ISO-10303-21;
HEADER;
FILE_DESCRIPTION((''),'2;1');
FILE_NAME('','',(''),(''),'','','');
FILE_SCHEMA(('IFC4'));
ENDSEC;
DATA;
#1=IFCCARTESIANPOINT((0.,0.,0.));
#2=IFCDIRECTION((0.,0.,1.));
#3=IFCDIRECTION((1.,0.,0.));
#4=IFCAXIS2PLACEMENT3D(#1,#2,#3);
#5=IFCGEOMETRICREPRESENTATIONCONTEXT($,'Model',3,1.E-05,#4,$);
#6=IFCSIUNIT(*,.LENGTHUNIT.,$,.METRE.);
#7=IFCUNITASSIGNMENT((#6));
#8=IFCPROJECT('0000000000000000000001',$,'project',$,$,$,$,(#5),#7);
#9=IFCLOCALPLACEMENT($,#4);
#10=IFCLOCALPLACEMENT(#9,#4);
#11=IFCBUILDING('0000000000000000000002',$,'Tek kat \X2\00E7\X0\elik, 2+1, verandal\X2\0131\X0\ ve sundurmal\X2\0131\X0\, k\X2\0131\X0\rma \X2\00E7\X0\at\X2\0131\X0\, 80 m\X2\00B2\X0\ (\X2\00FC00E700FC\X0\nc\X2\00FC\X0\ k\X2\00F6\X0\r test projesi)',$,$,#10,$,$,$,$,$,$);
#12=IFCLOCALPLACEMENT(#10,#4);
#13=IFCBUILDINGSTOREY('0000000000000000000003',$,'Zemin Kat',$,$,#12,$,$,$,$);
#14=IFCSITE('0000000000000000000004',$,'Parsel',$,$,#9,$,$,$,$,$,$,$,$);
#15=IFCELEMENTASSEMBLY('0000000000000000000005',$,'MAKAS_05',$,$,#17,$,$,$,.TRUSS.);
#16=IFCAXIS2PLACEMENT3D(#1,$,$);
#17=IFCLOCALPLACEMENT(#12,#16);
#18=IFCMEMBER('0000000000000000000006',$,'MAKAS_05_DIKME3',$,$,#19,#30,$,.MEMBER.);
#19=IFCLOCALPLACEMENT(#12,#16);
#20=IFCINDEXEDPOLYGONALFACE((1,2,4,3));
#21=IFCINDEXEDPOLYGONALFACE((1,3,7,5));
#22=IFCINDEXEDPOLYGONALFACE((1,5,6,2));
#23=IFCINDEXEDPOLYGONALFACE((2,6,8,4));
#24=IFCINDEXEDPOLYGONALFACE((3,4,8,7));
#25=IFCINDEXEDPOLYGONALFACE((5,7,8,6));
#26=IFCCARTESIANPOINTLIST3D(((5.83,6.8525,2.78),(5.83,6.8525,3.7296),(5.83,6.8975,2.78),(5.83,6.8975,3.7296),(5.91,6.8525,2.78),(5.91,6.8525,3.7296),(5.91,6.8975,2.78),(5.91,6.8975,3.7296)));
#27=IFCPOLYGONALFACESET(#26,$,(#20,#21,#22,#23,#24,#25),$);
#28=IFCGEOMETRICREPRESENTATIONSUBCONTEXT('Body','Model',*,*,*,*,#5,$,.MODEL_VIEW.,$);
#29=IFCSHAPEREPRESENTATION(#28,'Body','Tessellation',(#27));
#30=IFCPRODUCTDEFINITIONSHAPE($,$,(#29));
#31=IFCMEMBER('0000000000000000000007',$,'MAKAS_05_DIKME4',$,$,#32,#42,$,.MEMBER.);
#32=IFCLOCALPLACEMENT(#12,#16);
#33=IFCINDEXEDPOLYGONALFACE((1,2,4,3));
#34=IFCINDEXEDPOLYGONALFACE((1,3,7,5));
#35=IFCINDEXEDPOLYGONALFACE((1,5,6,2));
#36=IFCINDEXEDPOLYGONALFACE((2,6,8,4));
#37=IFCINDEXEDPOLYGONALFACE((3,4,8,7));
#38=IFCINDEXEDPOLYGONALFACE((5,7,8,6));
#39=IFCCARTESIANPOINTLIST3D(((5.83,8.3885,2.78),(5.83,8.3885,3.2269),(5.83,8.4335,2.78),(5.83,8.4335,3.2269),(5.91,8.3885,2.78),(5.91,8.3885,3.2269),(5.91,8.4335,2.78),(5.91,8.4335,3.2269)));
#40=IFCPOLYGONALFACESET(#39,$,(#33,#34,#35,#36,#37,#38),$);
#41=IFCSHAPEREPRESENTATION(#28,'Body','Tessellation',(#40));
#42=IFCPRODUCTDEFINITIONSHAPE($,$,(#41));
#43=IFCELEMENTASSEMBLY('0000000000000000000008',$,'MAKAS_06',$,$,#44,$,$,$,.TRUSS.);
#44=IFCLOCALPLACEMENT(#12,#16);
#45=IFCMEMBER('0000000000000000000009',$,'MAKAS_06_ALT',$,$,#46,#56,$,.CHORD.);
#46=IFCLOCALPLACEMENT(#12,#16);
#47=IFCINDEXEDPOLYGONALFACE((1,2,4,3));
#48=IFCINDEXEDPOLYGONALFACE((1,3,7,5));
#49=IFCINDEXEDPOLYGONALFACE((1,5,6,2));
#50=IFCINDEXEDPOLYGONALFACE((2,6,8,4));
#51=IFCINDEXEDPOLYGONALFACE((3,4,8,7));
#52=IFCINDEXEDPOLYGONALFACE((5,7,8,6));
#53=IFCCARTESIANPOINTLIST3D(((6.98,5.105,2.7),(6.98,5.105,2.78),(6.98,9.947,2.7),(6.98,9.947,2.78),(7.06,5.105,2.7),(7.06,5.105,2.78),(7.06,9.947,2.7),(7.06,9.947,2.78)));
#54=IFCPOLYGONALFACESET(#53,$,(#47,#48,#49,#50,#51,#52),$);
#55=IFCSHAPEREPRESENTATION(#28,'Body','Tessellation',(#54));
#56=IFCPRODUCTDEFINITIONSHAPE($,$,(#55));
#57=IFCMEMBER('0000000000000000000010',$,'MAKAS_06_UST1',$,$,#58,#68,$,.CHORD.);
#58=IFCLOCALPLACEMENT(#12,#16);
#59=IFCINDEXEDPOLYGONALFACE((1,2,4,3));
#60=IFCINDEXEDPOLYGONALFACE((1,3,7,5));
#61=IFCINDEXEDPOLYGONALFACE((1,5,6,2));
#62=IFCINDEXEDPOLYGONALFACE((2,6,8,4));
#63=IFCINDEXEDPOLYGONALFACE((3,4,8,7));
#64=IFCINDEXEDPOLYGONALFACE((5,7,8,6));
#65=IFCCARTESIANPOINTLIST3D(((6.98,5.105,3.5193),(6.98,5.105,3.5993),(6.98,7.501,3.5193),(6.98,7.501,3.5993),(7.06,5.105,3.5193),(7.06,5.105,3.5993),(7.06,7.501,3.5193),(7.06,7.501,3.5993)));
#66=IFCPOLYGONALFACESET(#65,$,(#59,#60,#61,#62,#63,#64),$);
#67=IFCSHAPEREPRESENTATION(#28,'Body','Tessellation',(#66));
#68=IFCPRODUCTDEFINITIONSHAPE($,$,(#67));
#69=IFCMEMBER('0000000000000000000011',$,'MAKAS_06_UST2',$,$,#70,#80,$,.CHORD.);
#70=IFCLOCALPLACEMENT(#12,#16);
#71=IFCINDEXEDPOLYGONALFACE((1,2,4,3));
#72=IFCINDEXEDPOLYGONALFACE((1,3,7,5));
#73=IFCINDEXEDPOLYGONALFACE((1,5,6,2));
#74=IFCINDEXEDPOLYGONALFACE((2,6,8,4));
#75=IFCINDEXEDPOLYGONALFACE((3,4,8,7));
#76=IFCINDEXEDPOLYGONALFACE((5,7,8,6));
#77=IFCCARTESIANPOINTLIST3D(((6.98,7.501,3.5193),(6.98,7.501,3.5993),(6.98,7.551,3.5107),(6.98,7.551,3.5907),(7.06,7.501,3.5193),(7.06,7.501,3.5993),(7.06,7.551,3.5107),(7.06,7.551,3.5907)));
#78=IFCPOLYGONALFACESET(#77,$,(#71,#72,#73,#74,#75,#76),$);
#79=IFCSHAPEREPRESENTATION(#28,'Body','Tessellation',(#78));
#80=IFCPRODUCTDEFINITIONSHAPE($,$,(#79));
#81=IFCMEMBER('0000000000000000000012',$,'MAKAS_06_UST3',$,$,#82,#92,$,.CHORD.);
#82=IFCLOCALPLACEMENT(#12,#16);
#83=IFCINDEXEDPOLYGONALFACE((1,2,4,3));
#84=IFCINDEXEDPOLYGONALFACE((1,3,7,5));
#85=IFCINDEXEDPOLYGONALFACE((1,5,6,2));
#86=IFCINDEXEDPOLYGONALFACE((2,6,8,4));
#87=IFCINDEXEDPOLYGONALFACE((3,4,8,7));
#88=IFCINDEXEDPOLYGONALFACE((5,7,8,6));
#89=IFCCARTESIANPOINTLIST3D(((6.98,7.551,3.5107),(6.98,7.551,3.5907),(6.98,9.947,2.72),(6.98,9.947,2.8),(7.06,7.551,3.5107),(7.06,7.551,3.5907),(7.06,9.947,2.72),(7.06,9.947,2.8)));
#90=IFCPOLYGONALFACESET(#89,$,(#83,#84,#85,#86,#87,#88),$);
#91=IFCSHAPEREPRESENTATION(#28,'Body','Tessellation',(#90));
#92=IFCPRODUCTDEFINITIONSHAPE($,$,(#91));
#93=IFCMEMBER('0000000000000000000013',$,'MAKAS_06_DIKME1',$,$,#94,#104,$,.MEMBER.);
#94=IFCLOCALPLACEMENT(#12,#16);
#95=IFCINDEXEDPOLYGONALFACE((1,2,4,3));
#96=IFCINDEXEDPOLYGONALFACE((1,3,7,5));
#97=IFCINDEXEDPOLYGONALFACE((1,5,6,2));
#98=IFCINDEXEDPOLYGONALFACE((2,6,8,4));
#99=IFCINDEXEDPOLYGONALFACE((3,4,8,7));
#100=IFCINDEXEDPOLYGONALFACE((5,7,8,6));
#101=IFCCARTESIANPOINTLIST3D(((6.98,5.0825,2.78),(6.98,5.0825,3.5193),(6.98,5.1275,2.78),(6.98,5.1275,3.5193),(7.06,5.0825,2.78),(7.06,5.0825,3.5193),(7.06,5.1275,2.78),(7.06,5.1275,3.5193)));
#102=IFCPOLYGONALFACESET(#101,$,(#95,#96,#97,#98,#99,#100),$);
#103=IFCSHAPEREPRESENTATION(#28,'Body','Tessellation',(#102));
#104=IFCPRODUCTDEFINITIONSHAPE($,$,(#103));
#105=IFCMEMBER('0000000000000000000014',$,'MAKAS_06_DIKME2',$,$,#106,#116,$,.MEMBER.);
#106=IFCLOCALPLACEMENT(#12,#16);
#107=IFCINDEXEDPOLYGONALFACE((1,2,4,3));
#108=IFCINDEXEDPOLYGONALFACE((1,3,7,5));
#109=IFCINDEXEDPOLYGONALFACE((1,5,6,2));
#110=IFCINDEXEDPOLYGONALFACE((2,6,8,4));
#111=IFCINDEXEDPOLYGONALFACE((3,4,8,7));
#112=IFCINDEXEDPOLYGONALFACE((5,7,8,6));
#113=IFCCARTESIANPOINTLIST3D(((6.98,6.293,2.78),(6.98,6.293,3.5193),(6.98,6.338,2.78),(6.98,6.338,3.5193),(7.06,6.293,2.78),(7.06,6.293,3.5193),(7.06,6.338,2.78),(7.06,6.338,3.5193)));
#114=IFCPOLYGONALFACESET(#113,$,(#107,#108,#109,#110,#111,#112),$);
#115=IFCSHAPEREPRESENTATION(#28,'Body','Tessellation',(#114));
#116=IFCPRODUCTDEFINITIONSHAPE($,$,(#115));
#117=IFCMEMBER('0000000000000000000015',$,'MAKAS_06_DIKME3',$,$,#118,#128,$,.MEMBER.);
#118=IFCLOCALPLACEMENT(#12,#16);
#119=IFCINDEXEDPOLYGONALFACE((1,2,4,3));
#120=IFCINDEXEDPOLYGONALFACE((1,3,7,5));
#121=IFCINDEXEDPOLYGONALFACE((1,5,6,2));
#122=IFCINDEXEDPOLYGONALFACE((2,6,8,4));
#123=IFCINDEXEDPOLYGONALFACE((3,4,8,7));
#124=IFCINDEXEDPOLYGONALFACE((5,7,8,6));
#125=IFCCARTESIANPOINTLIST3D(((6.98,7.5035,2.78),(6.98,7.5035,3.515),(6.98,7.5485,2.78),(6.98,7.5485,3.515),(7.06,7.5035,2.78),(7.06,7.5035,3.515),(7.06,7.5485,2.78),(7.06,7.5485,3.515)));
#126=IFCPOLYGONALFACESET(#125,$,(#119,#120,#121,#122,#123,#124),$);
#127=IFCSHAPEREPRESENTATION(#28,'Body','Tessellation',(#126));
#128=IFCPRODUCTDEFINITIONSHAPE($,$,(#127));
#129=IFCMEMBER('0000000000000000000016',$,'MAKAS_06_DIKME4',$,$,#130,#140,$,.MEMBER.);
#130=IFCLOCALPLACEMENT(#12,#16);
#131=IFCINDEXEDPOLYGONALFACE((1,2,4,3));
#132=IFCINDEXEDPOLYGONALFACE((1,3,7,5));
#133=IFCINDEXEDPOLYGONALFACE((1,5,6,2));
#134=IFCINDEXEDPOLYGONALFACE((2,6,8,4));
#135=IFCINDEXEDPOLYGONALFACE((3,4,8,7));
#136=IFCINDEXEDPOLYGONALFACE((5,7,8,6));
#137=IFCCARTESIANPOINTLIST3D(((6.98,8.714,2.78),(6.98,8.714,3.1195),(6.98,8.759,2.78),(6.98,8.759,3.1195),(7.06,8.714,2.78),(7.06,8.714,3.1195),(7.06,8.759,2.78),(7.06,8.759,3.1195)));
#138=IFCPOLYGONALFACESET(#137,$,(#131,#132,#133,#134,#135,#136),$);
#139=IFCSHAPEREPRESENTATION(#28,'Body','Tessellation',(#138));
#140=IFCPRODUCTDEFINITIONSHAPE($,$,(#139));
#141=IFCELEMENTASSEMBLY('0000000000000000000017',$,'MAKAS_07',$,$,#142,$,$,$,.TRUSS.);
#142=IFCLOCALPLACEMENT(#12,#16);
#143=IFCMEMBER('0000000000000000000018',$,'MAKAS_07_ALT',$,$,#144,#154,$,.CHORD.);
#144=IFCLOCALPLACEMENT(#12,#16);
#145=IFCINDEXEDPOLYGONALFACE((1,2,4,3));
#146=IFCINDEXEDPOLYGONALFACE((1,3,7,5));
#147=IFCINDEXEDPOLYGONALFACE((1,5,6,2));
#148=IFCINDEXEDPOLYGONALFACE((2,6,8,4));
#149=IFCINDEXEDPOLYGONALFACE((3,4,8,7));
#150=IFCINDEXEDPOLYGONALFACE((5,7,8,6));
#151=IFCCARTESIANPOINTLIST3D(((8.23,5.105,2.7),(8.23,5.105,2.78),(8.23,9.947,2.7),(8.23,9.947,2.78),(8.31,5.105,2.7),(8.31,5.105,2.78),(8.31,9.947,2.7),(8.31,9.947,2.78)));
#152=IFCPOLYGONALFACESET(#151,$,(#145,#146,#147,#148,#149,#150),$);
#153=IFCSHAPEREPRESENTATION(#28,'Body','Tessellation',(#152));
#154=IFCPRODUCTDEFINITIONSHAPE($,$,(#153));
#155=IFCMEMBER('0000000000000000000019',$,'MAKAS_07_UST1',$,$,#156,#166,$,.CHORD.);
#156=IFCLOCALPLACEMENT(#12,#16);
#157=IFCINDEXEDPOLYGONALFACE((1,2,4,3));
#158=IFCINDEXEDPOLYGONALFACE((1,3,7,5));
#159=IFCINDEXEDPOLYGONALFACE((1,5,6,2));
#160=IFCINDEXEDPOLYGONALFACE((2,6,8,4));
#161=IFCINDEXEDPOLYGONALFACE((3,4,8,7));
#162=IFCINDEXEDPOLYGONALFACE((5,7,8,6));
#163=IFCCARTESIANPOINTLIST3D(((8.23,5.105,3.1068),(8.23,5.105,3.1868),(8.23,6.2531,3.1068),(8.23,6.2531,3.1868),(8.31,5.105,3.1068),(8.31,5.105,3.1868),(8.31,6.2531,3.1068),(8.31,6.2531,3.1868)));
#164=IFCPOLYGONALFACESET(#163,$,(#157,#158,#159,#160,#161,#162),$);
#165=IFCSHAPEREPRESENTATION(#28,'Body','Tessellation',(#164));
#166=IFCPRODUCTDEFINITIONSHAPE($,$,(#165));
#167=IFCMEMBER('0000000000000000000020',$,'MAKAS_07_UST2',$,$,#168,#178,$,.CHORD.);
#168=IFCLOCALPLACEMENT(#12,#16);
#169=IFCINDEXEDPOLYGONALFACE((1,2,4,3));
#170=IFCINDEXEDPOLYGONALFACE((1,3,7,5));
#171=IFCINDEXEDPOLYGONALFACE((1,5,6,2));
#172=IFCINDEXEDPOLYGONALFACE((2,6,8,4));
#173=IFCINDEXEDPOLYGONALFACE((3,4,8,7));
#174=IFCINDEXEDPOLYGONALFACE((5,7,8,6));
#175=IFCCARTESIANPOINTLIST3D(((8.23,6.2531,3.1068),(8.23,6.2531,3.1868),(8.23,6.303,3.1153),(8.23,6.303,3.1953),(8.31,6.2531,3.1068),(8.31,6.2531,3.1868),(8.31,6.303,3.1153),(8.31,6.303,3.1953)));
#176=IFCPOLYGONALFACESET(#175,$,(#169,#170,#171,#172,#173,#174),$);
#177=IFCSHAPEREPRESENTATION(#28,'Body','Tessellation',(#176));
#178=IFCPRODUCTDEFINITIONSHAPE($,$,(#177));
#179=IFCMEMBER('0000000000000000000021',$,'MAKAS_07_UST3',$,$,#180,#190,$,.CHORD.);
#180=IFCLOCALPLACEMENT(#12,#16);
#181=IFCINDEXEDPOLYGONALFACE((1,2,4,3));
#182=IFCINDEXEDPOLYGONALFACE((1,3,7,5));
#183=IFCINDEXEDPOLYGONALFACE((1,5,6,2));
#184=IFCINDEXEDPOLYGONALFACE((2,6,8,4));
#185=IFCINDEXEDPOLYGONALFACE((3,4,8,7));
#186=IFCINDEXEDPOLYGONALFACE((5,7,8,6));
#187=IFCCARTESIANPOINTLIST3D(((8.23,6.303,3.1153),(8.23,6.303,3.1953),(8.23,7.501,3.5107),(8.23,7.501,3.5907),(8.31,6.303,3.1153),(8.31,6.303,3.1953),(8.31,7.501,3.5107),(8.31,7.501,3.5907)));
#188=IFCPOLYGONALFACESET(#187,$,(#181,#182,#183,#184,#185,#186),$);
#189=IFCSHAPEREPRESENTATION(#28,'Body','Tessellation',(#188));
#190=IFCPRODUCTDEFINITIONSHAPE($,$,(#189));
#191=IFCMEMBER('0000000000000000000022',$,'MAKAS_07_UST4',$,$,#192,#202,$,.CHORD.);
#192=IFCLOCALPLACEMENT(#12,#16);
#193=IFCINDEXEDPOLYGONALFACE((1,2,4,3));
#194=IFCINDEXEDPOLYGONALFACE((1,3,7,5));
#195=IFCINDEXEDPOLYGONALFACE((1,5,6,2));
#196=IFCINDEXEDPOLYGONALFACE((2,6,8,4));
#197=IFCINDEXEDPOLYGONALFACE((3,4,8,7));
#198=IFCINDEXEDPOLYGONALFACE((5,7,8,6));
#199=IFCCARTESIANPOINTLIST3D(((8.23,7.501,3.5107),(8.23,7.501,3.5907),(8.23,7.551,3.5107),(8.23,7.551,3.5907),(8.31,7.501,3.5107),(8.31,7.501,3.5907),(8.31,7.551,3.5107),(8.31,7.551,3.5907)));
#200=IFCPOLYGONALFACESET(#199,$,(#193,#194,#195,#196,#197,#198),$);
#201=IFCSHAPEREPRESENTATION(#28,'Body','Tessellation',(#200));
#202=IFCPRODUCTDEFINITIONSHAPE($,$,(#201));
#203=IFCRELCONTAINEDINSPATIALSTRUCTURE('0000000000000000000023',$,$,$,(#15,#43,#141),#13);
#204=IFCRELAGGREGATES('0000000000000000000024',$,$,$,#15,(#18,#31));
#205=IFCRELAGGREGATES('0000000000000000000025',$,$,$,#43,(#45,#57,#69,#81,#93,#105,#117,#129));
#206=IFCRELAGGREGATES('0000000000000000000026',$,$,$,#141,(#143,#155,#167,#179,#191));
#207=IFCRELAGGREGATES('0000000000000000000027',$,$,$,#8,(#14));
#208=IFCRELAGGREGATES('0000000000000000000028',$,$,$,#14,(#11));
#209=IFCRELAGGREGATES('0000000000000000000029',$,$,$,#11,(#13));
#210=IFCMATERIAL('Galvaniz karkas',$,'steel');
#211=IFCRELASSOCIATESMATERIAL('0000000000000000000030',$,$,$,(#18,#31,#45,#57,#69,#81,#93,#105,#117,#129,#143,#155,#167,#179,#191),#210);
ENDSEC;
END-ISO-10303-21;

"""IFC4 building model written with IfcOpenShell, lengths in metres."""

from ifc_helpers import new_model, si_unit, frame, origin_with_axes, place, context, subcontext, project, spatial, line, indexed_curve, outline, extrude, material, element, aggregate, save


model = new_model("IFC4")

# Units and contexts
model_context = context("Model", 3, precision=1e-05, world=origin_with_axes())
body_context = subcontext(model_context, "Body", "Model", "MODEL_VIEW")
ifc_project = project(units=[si_unit("LENGTHUNIT", "METRE")], contexts=[model_context])

# Site, building, storey
site_placement = place(None, origin_with_axes())
site = spatial("IfcSite", under=ifc_project, at=site_placement, Name="Parsel")
building_placement = place(site_placement, origin_with_axes())
building = spatial("IfcBuilding", under=site, at=building_placement, Name="Tek kat çelik, 2+1, verandalı ve sundurmalı, kırma çatı, 80 m² (üçüncü kör test projesi)")
storey_placement = place(building_placement, origin_with_axes())
storey = spatial("IfcBuildingStorey", under=building, at=storey_placement, Name="Zemin Kat")

# Element assemblies, members
ifc_material = material(Name="Galvaniz karkas", Category="steel")
assembly_1_placement = place(storey_placement, origin_with_axes())
assembly_1 = element("IfcElementAssembly", 1, at=assembly_1_placement, inside=storey, Name="MAKAS_05", PredefinedType="TRUSS")
member_1_placement = place(assembly_1_placement, origin_with_axes())
member_1 = element("IfcMember", 2, at=member_1_placement, material=ifc_material, Name="MAKAS_05_DIKME3", PredefinedType="MEMBER", context=body_context, shape_type="SweptSolid", body=[
    extrude(outline(indexed_curve([(6.8525, 2.78), (6.8975, 2.78), (6.8975, 3.7296), (6.8525, 3.7296)], segments=[line(1, 2, 3, 4, 1)])), frame((5.83, 0.0, 0.0), z_axis=(1.0, 0.0, 0.0), x_axis=(0.0, 1.0, 0.0)), (0.0, 0.0, 1.0), 0.08),
])
member_2_placement = place(assembly_1_placement, origin_with_axes())
member_2 = element("IfcMember", 3, at=member_2_placement, material=ifc_material, Name="MAKAS_05_DIKME4", PredefinedType="MEMBER", context=body_context, shape_type="SweptSolid", body=[
    extrude(outline(indexed_curve([(8.3885, 2.78), (8.4335, 2.78), (8.4335, 3.2269), (8.3885, 3.2269)], segments=[line(1, 2, 3, 4, 1)])), frame((5.83, 0.0, 0.0), z_axis=(1.0, 0.0, 0.0), x_axis=(0.0, 1.0, 0.0)), (0.0, 0.0, 1.0), 0.08),
])
aggregate(assembly_1, [member_1, member_2])
assembly_2_placement = place(storey_placement, origin_with_axes())
assembly_2 = element("IfcElementAssembly", 4, at=assembly_2_placement, inside=storey, Name="MAKAS_06", PredefinedType="TRUSS")
member_3_placement = place(assembly_2_placement, origin_with_axes())
member_3 = element("IfcMember", 5, at=member_3_placement, material=ifc_material, Name="MAKAS_06_ALT", PredefinedType="CHORD", context=body_context, shape_type="SweptSolid", body=[
    extrude(outline(indexed_curve([(5.105, 2.7), (9.947, 2.7), (9.947, 2.78), (5.105, 2.78)], segments=[line(1, 2, 3, 4, 1)])), frame((6.98, 0.0, 0.0), z_axis=(1.0, 0.0, 0.0), x_axis=(0.0, 1.0, 0.0)), (0.0, 0.0, 1.0), 0.08),
])
member_4_placement = place(assembly_2_placement, origin_with_axes())
member_4 = element("IfcMember", 6, at=member_4_placement, material=ifc_material, Name="MAKAS_06_UST1", PredefinedType="CHORD", context=body_context, shape_type="SweptSolid", body=[
    extrude(outline(indexed_curve([(5.105, 3.5193), (7.501, 3.5193), (7.501, 3.5993), (5.105, 3.5993)], segments=[line(1, 2, 3, 4, 1)])), frame((6.98, 0.0, 0.0), z_axis=(1.0, 0.0, 0.0), x_axis=(0.0, 1.0, 0.0)), (0.0, 0.0, 1.0), 0.08),
])
member_5_placement = place(assembly_2_placement, origin_with_axes())
member_5 = element("IfcMember", 7, at=member_5_placement, material=ifc_material, Name="MAKAS_06_UST2", PredefinedType="CHORD", context=body_context, shape_type="SweptSolid", body=[
    extrude(outline(indexed_curve([(7.501, 3.5193), (7.551, 3.5107), (7.551, 3.5907), (7.501, 3.5993)], segments=[line(1, 2, 3, 4, 1)])), frame((6.98, 0.0, 0.0), z_axis=(1.0, 0.0, 0.0), x_axis=(0.0, 1.0, 0.0)), (0.0, 0.0, 1.0), 0.08),
])
member_6_placement = place(assembly_2_placement, origin_with_axes())
member_6 = element("IfcMember", 8, at=member_6_placement, material=ifc_material, Name="MAKAS_06_UST3", PredefinedType="CHORD", context=body_context, shape_type="SweptSolid", body=[
    extrude(outline(indexed_curve([(7.551, 3.5107), (9.947, 2.72), (9.947, 2.8), (7.551, 3.5907)], segments=[line(1, 2, 3, 4, 1)])), frame((6.98, 0.0, 0.0), z_axis=(1.0, 0.0, 0.0), x_axis=(0.0, 1.0, 0.0)), (0.0, 0.0, 1.0), 0.08),
])
member_7_placement = place(assembly_2_placement, origin_with_axes())
member_7 = element("IfcMember", 9, at=member_7_placement, material=ifc_material, Name="MAKAS_06_DIKME1", PredefinedType="MEMBER", context=body_context, shape_type="SweptSolid", body=[
    extrude(outline(indexed_curve([(5.0825, 2.78), (5.1275, 2.78), (5.1275, 3.5193), (5.0825, 3.5193)], segments=[line(1, 2, 3, 4, 1)])), frame((6.98, 0.0, 0.0), z_axis=(1.0, 0.0, 0.0), x_axis=(0.0, 1.0, 0.0)), (0.0, 0.0, 1.0), 0.08),
])
member_8_placement = place(assembly_2_placement, origin_with_axes())
member_8 = element("IfcMember", 10, at=member_8_placement, material=ifc_material, Name="MAKAS_06_DIKME2", PredefinedType="MEMBER", context=body_context, shape_type="SweptSolid", body=[
    extrude(outline(indexed_curve([(6.293, 2.78), (6.338, 2.78), (6.338, 3.5193), (6.293, 3.5193)], segments=[line(1, 2, 3, 4, 1)])), frame((6.98, 0.0, 0.0), z_axis=(1.0, 0.0, 0.0), x_axis=(0.0, 1.0, 0.0)), (0.0, 0.0, 1.0), 0.08),
])
member_9_placement = place(assembly_2_placement, origin_with_axes())
member_9 = element("IfcMember", 11, at=member_9_placement, material=ifc_material, Name="MAKAS_06_DIKME3", PredefinedType="MEMBER", context=body_context, shape_type="SweptSolid", body=[
    extrude(outline(indexed_curve([(7.5035, 2.78), (7.5485, 2.78), (7.5485, 3.515), (7.5035, 3.515)], segments=[line(1, 2, 3, 4, 1)])), frame((6.98, 0.0, 0.0), z_axis=(1.0, 0.0, 0.0), x_axis=(0.0, 1.0, 0.0)), (0.0, 0.0, 1.0), 0.08),
])
member_10_placement = place(assembly_2_placement, origin_with_axes())
member_10 = element("IfcMember", 12, at=member_10_placement, material=ifc_material, Name="MAKAS_06_DIKME4", PredefinedType="MEMBER", context=body_context, shape_type="SweptSolid", body=[
    extrude(outline(indexed_curve([(8.714, 2.78), (8.759, 2.78), (8.759, 3.1195), (8.714, 3.1195)], segments=[line(1, 2, 3, 4, 1)])), frame((6.98, 0.0, 0.0), z_axis=(1.0, 0.0, 0.0), x_axis=(0.0, 1.0, 0.0)), (0.0, 0.0, 1.0), 0.08),
])
aggregate(assembly_2, [member_3, member_4, member_5, member_6, member_7, member_8, member_9, member_10])
assembly_3_placement = place(storey_placement, origin_with_axes())
assembly_3 = element("IfcElementAssembly", 13, at=assembly_3_placement, inside=storey, Name="MAKAS_07", PredefinedType="TRUSS")
member_11_placement = place(assembly_3_placement, origin_with_axes())
member_11 = element("IfcMember", 14, at=member_11_placement, material=ifc_material, Name="MAKAS_07_ALT", PredefinedType="CHORD", context=body_context, shape_type="SweptSolid", body=[
    extrude(outline(indexed_curve([(5.105, 2.7), (9.947, 2.7), (9.947, 2.78), (5.105, 2.78)], segments=[line(1, 2, 3, 4, 1)])), frame((8.23, 0.0, 0.0), z_axis=(1.0, 0.0, 0.0), x_axis=(0.0, 1.0, 0.0)), (0.0, 0.0, 1.0), 0.08),
])
member_12_placement = place(assembly_3_placement, origin_with_axes())
member_12 = element("IfcMember", 15, at=member_12_placement, material=ifc_material, Name="MAKAS_07_UST1", PredefinedType="CHORD", context=body_context, shape_type="SweptSolid", body=[
    extrude(outline(indexed_curve([(5.105, 3.1068), (6.2531, 3.1068), (6.2531, 3.1868), (5.105, 3.1868)], segments=[line(1, 2, 3, 4, 1)])), frame((8.23, 0.0, 0.0), z_axis=(1.0, 0.0, 0.0), x_axis=(0.0, 1.0, 0.0)), (0.0, 0.0, 1.0), 0.08),
])
member_13_placement = place(assembly_3_placement, origin_with_axes())
member_13 = element("IfcMember", 16, at=member_13_placement, material=ifc_material, Name="MAKAS_07_UST2", PredefinedType="CHORD", context=body_context, shape_type="SweptSolid", body=[
    extrude(outline(indexed_curve([(6.2531, 3.1068), (6.303, 3.1153), (6.303, 3.1953), (6.2531, 3.1868)], segments=[line(1, 2, 3, 4, 1)])), frame((8.23, 0.0, 0.0), z_axis=(1.0, 0.0, 0.0), x_axis=(0.0, 1.0, 0.0)), (0.0, 0.0, 1.0), 0.08),
])
member_14_placement = place(assembly_3_placement, origin_with_axes())
member_14 = element("IfcMember", 17, at=member_14_placement, material=ifc_material, Name="MAKAS_07_UST3", PredefinedType="CHORD", context=body_context, shape_type="SweptSolid", body=[
    extrude(outline(indexed_curve([(6.303, 3.1153), (7.501, 3.5107), (7.501, 3.5907), (6.303, 3.1953)], segments=[line(1, 2, 3, 4, 1)])), frame((8.23, 0.0, 0.0), z_axis=(1.0, 0.0, 0.0), x_axis=(0.0, 1.0, 0.0)), (0.0, 0.0, 1.0), 0.08),
])
member_15_placement = place(assembly_3_placement, origin_with_axes())
member_15 = element("IfcMember", 18, at=member_15_placement, material=ifc_material, Name="MAKAS_07_UST4", PredefinedType="CHORD", context=body_context, shape_type="SweptSolid", body=[
    extrude(outline(indexed_curve([(7.501, 3.5107), (7.551, 3.5107), (7.551, 3.5907), (7.501, 3.5907)], segments=[line(1, 2, 3, 4, 1)])), frame((8.23, 0.0, 0.0), z_axis=(1.0, 0.0, 0.0), x_axis=(0.0, 1.0, 0.0)), (0.0, 0.0, 1.0), 0.08),
])
aggregate(assembly_3, [member_11, member_12, member_13, member_14, member_15])

save(model, "model.ifc")
